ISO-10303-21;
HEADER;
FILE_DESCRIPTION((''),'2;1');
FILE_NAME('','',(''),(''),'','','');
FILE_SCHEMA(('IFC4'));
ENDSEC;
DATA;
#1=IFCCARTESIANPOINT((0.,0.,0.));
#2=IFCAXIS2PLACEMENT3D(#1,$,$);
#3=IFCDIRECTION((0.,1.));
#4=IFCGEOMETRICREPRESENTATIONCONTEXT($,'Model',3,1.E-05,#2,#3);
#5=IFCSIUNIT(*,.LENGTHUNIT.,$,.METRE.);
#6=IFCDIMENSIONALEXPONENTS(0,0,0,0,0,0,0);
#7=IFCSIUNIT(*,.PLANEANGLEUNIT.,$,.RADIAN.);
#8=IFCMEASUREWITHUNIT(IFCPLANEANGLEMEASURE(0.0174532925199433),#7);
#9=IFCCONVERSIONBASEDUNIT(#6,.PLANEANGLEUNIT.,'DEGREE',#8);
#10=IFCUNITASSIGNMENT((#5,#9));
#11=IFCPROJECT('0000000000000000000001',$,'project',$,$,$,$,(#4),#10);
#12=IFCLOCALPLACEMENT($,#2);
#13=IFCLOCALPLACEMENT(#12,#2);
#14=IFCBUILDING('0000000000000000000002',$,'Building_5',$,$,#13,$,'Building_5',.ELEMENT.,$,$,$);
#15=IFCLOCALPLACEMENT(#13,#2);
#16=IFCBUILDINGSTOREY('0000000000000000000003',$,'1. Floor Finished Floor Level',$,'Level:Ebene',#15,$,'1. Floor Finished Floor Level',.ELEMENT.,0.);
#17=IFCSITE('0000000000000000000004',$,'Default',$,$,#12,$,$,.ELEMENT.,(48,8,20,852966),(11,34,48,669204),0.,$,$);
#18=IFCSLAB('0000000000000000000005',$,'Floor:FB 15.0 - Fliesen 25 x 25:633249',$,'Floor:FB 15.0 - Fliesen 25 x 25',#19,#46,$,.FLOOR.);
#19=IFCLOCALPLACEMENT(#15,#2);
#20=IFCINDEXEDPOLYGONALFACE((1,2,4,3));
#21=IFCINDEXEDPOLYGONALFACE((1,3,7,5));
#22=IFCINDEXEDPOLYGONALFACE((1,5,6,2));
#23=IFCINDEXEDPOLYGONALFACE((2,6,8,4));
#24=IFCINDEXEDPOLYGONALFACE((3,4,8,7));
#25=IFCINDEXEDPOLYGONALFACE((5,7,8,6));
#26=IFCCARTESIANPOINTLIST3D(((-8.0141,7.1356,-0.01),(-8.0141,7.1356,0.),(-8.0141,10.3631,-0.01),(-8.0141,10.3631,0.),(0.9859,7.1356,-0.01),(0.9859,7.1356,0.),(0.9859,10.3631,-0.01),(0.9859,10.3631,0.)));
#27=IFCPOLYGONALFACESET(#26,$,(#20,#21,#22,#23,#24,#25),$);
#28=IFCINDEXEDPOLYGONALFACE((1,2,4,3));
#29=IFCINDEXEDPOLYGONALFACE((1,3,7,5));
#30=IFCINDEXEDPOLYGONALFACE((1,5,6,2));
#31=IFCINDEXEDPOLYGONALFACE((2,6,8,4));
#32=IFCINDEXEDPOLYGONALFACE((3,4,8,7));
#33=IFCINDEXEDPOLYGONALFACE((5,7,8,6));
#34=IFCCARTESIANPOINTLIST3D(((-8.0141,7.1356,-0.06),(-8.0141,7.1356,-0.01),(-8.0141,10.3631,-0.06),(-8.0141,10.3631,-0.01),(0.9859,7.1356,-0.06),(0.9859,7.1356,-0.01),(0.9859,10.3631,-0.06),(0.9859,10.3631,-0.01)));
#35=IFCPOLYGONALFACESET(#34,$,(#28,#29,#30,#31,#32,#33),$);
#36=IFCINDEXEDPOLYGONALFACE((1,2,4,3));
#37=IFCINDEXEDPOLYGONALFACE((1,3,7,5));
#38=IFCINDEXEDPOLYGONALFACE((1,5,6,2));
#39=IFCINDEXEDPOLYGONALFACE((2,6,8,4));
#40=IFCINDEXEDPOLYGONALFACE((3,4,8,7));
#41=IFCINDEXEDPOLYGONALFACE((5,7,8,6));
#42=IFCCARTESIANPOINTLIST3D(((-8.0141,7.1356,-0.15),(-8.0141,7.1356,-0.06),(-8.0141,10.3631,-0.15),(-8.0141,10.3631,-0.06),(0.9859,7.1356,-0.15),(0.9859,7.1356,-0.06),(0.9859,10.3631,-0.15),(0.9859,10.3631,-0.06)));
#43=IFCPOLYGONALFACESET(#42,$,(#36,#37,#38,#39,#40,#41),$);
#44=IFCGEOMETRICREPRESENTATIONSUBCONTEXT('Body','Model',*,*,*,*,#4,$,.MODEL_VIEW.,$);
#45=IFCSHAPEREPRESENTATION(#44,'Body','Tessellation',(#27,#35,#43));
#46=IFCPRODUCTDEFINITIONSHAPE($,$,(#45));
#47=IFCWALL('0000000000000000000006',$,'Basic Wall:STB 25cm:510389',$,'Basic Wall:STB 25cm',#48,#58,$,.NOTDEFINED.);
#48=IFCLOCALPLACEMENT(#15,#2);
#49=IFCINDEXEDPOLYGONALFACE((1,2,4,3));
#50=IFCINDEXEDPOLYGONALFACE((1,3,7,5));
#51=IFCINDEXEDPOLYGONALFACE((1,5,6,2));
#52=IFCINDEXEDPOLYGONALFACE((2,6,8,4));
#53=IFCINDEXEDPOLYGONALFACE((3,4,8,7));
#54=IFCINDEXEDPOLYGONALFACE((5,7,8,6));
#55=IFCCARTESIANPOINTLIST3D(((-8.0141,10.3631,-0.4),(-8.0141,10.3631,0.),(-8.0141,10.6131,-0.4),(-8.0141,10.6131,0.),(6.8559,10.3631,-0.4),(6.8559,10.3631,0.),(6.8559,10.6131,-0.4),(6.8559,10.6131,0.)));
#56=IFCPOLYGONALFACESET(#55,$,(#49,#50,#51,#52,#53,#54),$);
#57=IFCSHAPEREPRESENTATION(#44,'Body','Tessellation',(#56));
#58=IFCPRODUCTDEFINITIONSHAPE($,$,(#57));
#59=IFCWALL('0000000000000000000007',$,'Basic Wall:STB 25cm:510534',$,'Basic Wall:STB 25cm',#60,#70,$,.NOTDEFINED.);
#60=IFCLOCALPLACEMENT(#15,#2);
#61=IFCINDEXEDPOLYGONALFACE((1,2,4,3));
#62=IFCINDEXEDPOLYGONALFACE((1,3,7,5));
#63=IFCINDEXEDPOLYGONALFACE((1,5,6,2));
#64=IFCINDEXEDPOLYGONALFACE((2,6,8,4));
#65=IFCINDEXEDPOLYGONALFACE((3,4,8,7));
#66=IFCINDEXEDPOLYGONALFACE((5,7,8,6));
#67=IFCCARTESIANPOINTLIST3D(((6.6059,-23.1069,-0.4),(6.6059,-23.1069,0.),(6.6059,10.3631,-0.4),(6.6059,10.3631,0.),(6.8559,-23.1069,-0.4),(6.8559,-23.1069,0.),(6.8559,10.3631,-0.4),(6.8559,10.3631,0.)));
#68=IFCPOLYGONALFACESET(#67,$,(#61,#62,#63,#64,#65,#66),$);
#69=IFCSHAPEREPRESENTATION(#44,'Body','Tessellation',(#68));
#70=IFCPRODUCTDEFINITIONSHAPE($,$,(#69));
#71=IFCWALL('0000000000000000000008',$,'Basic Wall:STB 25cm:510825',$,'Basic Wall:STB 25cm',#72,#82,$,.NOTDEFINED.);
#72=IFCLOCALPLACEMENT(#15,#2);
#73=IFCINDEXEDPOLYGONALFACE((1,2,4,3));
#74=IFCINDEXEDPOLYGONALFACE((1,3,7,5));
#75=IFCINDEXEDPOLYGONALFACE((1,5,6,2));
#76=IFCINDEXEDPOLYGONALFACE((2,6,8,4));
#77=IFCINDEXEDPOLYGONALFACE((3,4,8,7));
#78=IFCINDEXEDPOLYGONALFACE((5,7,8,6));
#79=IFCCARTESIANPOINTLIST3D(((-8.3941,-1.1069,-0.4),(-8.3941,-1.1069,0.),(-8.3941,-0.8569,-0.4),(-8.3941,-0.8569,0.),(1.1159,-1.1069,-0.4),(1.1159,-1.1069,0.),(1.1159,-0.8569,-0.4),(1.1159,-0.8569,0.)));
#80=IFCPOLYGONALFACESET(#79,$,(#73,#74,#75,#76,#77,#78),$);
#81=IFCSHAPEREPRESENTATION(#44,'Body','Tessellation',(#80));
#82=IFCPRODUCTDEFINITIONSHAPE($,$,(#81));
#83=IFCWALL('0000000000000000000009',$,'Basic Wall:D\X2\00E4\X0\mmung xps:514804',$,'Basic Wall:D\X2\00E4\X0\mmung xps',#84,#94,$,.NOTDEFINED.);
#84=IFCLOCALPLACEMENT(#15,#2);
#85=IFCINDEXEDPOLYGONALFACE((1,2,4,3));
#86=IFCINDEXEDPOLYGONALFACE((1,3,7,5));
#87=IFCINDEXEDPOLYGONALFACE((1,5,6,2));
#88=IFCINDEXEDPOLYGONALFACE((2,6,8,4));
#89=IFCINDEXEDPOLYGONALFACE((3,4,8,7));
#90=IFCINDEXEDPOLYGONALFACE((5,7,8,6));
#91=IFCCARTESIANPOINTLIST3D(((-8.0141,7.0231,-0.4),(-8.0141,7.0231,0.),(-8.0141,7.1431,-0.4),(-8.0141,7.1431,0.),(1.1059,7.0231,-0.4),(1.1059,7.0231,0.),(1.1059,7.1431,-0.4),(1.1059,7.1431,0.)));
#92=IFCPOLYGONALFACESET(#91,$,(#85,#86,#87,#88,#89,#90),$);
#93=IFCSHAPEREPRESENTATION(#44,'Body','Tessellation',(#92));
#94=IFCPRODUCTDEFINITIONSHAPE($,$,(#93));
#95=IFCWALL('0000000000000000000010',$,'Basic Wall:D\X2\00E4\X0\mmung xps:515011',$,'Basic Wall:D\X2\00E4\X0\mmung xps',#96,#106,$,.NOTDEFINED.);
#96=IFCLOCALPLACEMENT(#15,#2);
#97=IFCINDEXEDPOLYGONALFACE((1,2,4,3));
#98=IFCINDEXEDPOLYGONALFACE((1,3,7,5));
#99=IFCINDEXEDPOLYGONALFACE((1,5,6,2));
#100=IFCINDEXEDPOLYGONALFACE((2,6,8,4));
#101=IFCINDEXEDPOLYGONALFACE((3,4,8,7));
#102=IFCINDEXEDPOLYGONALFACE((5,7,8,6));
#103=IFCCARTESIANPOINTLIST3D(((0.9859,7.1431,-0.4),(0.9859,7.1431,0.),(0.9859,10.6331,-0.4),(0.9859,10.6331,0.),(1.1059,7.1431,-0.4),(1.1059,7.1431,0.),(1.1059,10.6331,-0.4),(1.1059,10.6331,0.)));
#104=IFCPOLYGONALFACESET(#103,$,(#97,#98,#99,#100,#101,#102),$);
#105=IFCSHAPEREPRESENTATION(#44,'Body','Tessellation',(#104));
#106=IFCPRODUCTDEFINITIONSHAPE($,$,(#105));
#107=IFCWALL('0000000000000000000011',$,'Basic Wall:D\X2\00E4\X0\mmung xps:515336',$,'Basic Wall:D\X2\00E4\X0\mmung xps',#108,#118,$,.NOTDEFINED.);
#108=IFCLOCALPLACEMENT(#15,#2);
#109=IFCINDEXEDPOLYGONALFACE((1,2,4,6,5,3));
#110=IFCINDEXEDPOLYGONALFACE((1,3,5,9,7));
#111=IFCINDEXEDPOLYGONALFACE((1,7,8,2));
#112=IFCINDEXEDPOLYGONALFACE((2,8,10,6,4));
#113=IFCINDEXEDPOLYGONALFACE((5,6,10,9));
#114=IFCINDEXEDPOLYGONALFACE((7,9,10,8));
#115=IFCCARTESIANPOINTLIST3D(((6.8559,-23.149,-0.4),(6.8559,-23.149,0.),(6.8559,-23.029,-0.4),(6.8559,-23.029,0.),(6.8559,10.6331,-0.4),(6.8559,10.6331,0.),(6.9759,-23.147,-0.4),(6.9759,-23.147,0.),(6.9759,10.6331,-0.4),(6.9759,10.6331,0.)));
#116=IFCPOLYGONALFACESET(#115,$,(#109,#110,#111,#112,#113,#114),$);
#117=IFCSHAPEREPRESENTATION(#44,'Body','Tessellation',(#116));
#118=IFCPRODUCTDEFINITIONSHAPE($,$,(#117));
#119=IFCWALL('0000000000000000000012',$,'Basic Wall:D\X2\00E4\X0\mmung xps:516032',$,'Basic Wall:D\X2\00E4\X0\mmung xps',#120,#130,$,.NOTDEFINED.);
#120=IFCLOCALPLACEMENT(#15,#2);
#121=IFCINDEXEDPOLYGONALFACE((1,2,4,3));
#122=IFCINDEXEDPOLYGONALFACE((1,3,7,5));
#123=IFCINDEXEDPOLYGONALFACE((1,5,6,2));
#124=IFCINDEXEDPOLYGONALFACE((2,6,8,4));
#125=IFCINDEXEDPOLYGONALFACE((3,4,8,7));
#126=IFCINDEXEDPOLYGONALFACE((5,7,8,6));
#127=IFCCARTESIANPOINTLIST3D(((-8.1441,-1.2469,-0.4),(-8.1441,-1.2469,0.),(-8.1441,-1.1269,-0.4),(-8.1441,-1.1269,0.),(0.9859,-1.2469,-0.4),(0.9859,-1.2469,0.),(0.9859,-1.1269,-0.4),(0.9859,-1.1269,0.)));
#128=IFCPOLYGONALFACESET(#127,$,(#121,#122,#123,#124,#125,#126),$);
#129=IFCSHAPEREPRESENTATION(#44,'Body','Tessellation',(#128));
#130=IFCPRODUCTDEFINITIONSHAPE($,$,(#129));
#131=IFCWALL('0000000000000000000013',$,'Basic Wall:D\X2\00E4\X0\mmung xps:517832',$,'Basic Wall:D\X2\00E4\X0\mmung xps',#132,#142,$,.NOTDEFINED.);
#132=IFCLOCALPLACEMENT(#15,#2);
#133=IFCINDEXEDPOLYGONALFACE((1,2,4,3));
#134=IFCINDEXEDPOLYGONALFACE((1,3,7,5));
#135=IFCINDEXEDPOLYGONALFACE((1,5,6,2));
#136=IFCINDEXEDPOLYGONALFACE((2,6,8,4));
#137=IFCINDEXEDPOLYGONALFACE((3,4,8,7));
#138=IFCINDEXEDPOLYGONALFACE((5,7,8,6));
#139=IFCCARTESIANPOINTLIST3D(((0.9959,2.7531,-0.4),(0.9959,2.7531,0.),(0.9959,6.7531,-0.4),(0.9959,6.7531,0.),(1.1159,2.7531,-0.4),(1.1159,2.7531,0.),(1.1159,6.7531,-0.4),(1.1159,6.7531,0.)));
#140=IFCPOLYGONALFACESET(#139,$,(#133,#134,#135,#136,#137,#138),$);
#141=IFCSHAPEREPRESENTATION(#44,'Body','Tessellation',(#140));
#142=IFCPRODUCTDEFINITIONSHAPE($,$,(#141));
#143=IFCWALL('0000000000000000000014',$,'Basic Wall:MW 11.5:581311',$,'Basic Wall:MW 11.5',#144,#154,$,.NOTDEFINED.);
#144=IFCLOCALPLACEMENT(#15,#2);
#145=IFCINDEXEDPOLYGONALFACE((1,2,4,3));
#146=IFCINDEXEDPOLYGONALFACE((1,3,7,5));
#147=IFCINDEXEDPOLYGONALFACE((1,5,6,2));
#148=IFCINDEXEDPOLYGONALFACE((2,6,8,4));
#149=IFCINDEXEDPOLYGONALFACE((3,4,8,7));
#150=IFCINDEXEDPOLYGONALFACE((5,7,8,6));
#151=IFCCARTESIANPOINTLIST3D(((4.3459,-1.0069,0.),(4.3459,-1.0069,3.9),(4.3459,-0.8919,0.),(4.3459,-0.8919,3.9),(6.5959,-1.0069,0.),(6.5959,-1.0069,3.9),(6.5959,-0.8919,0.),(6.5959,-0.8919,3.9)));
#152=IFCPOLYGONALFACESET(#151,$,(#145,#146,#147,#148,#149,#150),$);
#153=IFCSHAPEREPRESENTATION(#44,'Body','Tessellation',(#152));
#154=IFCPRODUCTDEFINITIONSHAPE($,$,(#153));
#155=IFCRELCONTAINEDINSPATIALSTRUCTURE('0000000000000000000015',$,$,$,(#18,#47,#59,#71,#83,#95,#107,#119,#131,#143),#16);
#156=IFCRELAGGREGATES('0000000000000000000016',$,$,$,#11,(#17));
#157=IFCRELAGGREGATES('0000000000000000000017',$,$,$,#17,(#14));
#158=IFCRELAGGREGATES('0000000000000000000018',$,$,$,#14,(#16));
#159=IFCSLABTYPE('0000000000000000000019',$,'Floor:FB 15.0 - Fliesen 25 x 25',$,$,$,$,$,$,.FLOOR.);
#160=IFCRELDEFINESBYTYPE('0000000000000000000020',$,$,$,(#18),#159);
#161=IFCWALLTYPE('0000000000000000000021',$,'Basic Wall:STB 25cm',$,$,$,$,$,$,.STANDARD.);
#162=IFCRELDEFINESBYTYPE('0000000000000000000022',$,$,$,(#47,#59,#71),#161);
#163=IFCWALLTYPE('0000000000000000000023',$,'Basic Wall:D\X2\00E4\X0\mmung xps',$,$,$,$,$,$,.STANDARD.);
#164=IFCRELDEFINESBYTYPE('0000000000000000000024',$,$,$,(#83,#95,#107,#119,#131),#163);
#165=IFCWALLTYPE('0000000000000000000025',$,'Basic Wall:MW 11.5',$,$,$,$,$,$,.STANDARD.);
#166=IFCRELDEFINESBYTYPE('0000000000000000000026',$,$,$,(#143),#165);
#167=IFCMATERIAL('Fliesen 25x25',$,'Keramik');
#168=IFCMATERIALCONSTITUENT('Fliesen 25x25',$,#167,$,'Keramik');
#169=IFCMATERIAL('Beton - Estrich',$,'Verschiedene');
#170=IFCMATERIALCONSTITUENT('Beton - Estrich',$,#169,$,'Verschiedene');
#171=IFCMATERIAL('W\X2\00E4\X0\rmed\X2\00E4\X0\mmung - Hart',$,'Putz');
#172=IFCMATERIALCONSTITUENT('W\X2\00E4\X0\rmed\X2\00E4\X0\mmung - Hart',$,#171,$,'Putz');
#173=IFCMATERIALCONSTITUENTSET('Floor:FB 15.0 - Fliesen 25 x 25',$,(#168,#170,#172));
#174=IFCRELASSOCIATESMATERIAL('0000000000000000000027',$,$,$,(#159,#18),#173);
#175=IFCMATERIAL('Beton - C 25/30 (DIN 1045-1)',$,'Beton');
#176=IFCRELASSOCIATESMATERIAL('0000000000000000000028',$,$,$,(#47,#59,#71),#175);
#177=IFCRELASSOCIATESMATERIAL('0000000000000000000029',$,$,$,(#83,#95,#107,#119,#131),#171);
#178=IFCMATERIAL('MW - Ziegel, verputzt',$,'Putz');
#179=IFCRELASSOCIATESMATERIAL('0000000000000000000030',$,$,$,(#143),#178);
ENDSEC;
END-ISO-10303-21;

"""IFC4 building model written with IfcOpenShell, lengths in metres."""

from ifc_helpers import new_model, entity, si_unit, converted_unit, direction, frame, origin, place, context, subcontext, project, spatial, indexed_curve, outline, extrude, material, constituent, constituent_set, type_object, element, save


model = new_model("IFC4")

# Units and contexts
model_context = context("Model", 3, precision=1e-05, world=origin(), true_north=direction((0.0, 1.0)))
body_context = subcontext(model_context, "Body", "Model", "MODEL_VIEW")
ifc_project = project(units=[si_unit("LENGTHUNIT", "METRE"), converted_unit("PLANEANGLEUNIT", "DEGREE", entity("IfcPlaneAngleMeasure", 0.0174532925199433), si_unit("PLANEANGLEUNIT", "RADIAN"), dimensions=[0, 0, 0, 0, 0, 0, 0])], contexts=[model_context])

# Site, building, storey
site_placement = place(None, origin())
site = spatial("IfcSite", under=ifc_project, at=site_placement, Name="Default", CompositionType="ELEMENT", RefLatitude=(48, 8, 20, 852966), RefLongitude=(11, 34, 48, 669204), RefElevation=0.0)
building_placement = place(site_placement, origin())
building = spatial("IfcBuilding", under=site, at=building_placement, Name="Building_5", LongName="Building_5", CompositionType="ELEMENT")
storey_placement = place(building_placement, origin())
storey = spatial("IfcBuildingStorey", under=building, at=storey_placement, Name="1. Floor Finished Floor Level", ObjectType="Level:Ebene", LongName="1. Floor Finished Floor Level", CompositionType="ELEMENT", Elevation=0.0)

# Slab
ifc_material_1 = material(Name="Beton - Estrich", Category="Verschiedene")
ifc_material_2 = material(Name="Wärmedämmung - Hart", Category="Putz")
ifc_material_3 = material(Name="Beton - C 25/30 (DIN 1045-1)", Category="Beton")
ifc_material_4 = material(Name="Fliesen 25x25", Category="Keramik")
ifc_constituent_1 = constituent(ifc_material_4, Name="Fliesen 25x25", Category="Keramik")
ifc_constituent_2 = constituent(ifc_material_1, Name="Beton - Estrich", Category="Verschiedene")
ifc_constituent_3 = constituent(ifc_material_2, Name="Wärmedämmung - Hart", Category="Putz")
ifc_constituent_set_1 = constituent_set(constituents=[ifc_constituent_1, ifc_constituent_2, ifc_constituent_3], Name="Floor:FB 15.0 - Fliesen 25 x 25")
slab_type_1 = type_object("IfcSlabType", Name="Floor:FB 15.0 - Fliesen 25 x 25", PredefinedType="FLOOR", material=ifc_constituent_set_1)
slab_1_placement = place(storey_placement, origin())
element("IfcSlab", 1, at=slab_1_placement, inside=storey, type_object=slab_type_1, material=ifc_constituent_set_1, Name="Floor:FB 15.0 - Fliesen 25 x 25:633249", ObjectType="Floor:FB 15.0 - Fliesen 25 x 25", PredefinedType="FLOOR", context=body_context, shape_type="SweptSolid", body=[
    extrude(outline(indexed_curve([(-4.5, -1.6138), (4.5, -1.6138), (4.5, 1.6138), (-4.5, 1.6138), (-4.5, -1.6138)], self_intersect=False)), frame((-3.5141, 8.7494, -0.01), z_axis=(0.0, 0.0, 1.0), x_axis=(-1.0, 0.0, 0.0)), (0.0, 0.0, 1.0), 0.01),
    extrude(outline(indexed_curve([(-4.5, -1.6138), (4.5, -1.6138), (4.5, 1.6138), (-4.5, 1.6138), (-4.5, -1.6138)], self_intersect=False)), frame((-3.5141, 8.7494, -0.06), z_axis=(0.0, 0.0, 1.0), x_axis=(-1.0, 0.0, 0.0)), (0.0, 0.0, 1.0), 0.05),
    extrude(outline(indexed_curve([(-4.5, -1.6138), (4.5, -1.6138), (4.5, 1.6138), (-4.5, 1.6138), (-4.5, -1.6138)], self_intersect=False)), frame((-3.5141, 8.7494, -0.15), z_axis=(0.0, 0.0, 1.0), x_axis=(-1.0, 0.0, 0.0)), (0.0, 0.0, 1.0), 0.09),
])

# Walls
wall_type_1 = type_object("IfcWallType", Name="Basic Wall:STB 25cm", PredefinedType="STANDARD")
wall_1_placement = place(storey_placement, frame((-8.0141, 10.4881, -0.4)))
element("IfcWall", 2, at=wall_1_placement, inside=storey, type_object=wall_type_1, material=ifc_material_3, Name="Basic Wall:STB 25cm:510389", ObjectType="Basic Wall:STB 25cm", PredefinedType="NOTDEFINED", context=body_context, shape_type="SweptSolid", body=[
    extrude(outline(indexed_curve([(14.87, 0.125), (0.0, 0.125), (0.0, -0.125), (14.87, -0.125), (14.87, 0.125)], self_intersect=False)), origin(), (0.0, 0.0, 1.0), 0.4),
])
wall_2_placement = place(storey_placement, frame((6.7309, 10.3631, -0.4), z_axis=(0.0, 0.0, 1.0), x_axis=(0.0, -1.0, 0.0)))
element("IfcWall", 3, at=wall_2_placement, inside=storey, type_object=wall_type_1, material=ifc_material_3, Name="Basic Wall:STB 25cm:510534", ObjectType="Basic Wall:STB 25cm", PredefinedType="NOTDEFINED", context=body_context, shape_type="SweptSolid", body=[
    extrude(outline(indexed_curve([(33.47, 0.125), (0.0, 0.125), (0.0, -0.125), (33.47, -0.125), (33.47, 0.125)], self_intersect=False)), origin(), (0.0, 0.0, 1.0), 0.4),
])
wall_3_placement = place(storey_placement, frame((1.1159, -0.9819, -0.4), z_axis=(0.0, 0.0, 1.0), x_axis=(-1.0, 0.0, 0.0)))
element("IfcWall", 4, at=wall_3_placement, inside=storey, type_object=wall_type_1, material=ifc_material_3, Name="Basic Wall:STB 25cm:510825", ObjectType="Basic Wall:STB 25cm", PredefinedType="NOTDEFINED", context=body_context, shape_type="SweptSolid", body=[
    extrude(outline(indexed_curve([(9.51, 0.125), (0.0, 0.125), (0.0, -0.125), (9.51, -0.125), (9.51, 0.125)], self_intersect=False)), origin(), (0.0, 0.0, 1.0), 0.4),
])
wall_type_2 = type_object("IfcWallType", Name="Basic Wall:Dämmung xps", PredefinedType="STANDARD")
wall_4_placement = place(storey_placement, frame((-8.0141, 7.0831, -0.4)))
element("IfcWall", 5, at=wall_4_placement, inside=storey, type_object=wall_type_2, material=ifc_material_2, Name="Basic Wall:Dämmung xps:514804", ObjectType="Basic Wall:Dämmung xps", PredefinedType="NOTDEFINED", context=body_context, shape_type="SweptSolid", body=[
    extrude(outline(indexed_curve([(9.12, 0.06), (0.0, 0.06), (0.0, -0.06), (9.12, -0.06), (9.12, 0.06)], self_intersect=False)), origin(), (0.0, 0.0, 1.0), 0.4),
])
wall_5_placement = place(storey_placement, frame((1.0459, 7.1431, -0.4), z_axis=(0.0, 0.0, 1.0), x_axis=(0.0, 1.0, 0.0)))
element("IfcWall", 6, at=wall_5_placement, inside=storey, type_object=wall_type_2, material=ifc_material_2, Name="Basic Wall:Dämmung xps:515011", ObjectType="Basic Wall:Dämmung xps", PredefinedType="NOTDEFINED", context=body_context, shape_type="SweptSolid", body=[
    extrude(outline(indexed_curve([(3.49, 0.06), (0.0, 0.06), (0.0, -0.06), (3.49, -0.06), (3.49, 0.06)], self_intersect=False)), origin(), (0.0, 0.0, 1.0), 0.4),
])
wall_6_placement = place(storey_placement, frame((6.9159, 10.6331, -0.4), z_axis=(0.0, 0.0, 1.0), x_axis=(0.0, -1.0, 0.0)))
element("IfcWall", 7, at=wall_6_placement, inside=storey, type_object=wall_type_2, material=ifc_material_2, Name="Basic Wall:Dämmung xps:515336", ObjectType="Basic Wall:Dämmung xps", PredefinedType="NOTDEFINED", context=body_context, shape_type="SweptSolid", body=[
    extrude(outline(indexed_curve([(33.7822, -0.06), (33.7802, 0.06), (0.0, 0.06), (0.0, -0.06), (33.6622, -0.06), (33.7822, -0.06)], self_intersect=False)), origin(), (0.0, 0.0, 1.0), 0.4),
])
wall_7_placement = place(storey_placement, frame((0.9859, -1.1869, -0.4), z_axis=(0.0, 0.0, 1.0), x_axis=(-1.0, 0.0, 0.0)))
element("IfcWall", 8, at=wall_7_placement, inside=storey, type_object=wall_type_2, material=ifc_material_2, Name="Basic Wall:Dämmung xps:516032", ObjectType="Basic Wall:Dämmung xps", PredefinedType="NOTDEFINED", context=body_context, shape_type="SweptSolid", body=[
    extrude(outline(indexed_curve([(9.13, 0.06), (0.0, 0.06), (0.0, -0.06), (9.13, -0.06), (9.13, 0.06)], self_intersect=False)), origin(), (0.0, 0.0, 1.0), 0.4),
])
wall_8_placement = place(storey_placement, frame((1.0559, 2.7531, -0.4), z_axis=(0.0, 0.0, 1.0), x_axis=(0.0, 1.0, 0.0)))
element("IfcWall", 9, at=wall_8_placement, inside=storey, type_object=wall_type_2, material=ifc_material_2, Name="Basic Wall:Dämmung xps:517832", ObjectType="Basic Wall:Dämmung xps", PredefinedType="NOTDEFINED", context=body_context, shape_type="SweptSolid", body=[
    extrude(outline(indexed_curve([(4.0, 0.06), (0.0, 0.06), (0.0, -0.06), (4.0, -0.06), (4.0, 0.06)], self_intersect=False)), origin(), (0.0, 0.0, 1.0), 0.4),
])

# Wall
ifc_material_5 = material(Name="MW - Ziegel, verputzt", Category="Putz")
wall_type_3 = type_object("IfcWallType", Name="Basic Wall:MW 11.5", PredefinedType="STANDARD")
wall_9_placement = place(storey_placement, frame((4.3459, -0.9494, 0.0)))
element("IfcWall", 10, at=wall_9_placement, inside=storey, type_object=wall_type_3, material=ifc_material_5, Name="Basic Wall:MW 11.5:581311", ObjectType="Basic Wall:MW 11.5", PredefinedType="NOTDEFINED", context=body_context, shape_type="SweptSolid", body=[
    extrude(outline(indexed_curve([(2.25, 0.0575), (0.0, 0.0575), (0.0, -0.0575), (2.25, -0.0575), (2.25, 0.0575)], self_intersect=False)), origin(), (0.0, 0.0, 1.0), 3.9),
])

save(model, "model.ifc")
